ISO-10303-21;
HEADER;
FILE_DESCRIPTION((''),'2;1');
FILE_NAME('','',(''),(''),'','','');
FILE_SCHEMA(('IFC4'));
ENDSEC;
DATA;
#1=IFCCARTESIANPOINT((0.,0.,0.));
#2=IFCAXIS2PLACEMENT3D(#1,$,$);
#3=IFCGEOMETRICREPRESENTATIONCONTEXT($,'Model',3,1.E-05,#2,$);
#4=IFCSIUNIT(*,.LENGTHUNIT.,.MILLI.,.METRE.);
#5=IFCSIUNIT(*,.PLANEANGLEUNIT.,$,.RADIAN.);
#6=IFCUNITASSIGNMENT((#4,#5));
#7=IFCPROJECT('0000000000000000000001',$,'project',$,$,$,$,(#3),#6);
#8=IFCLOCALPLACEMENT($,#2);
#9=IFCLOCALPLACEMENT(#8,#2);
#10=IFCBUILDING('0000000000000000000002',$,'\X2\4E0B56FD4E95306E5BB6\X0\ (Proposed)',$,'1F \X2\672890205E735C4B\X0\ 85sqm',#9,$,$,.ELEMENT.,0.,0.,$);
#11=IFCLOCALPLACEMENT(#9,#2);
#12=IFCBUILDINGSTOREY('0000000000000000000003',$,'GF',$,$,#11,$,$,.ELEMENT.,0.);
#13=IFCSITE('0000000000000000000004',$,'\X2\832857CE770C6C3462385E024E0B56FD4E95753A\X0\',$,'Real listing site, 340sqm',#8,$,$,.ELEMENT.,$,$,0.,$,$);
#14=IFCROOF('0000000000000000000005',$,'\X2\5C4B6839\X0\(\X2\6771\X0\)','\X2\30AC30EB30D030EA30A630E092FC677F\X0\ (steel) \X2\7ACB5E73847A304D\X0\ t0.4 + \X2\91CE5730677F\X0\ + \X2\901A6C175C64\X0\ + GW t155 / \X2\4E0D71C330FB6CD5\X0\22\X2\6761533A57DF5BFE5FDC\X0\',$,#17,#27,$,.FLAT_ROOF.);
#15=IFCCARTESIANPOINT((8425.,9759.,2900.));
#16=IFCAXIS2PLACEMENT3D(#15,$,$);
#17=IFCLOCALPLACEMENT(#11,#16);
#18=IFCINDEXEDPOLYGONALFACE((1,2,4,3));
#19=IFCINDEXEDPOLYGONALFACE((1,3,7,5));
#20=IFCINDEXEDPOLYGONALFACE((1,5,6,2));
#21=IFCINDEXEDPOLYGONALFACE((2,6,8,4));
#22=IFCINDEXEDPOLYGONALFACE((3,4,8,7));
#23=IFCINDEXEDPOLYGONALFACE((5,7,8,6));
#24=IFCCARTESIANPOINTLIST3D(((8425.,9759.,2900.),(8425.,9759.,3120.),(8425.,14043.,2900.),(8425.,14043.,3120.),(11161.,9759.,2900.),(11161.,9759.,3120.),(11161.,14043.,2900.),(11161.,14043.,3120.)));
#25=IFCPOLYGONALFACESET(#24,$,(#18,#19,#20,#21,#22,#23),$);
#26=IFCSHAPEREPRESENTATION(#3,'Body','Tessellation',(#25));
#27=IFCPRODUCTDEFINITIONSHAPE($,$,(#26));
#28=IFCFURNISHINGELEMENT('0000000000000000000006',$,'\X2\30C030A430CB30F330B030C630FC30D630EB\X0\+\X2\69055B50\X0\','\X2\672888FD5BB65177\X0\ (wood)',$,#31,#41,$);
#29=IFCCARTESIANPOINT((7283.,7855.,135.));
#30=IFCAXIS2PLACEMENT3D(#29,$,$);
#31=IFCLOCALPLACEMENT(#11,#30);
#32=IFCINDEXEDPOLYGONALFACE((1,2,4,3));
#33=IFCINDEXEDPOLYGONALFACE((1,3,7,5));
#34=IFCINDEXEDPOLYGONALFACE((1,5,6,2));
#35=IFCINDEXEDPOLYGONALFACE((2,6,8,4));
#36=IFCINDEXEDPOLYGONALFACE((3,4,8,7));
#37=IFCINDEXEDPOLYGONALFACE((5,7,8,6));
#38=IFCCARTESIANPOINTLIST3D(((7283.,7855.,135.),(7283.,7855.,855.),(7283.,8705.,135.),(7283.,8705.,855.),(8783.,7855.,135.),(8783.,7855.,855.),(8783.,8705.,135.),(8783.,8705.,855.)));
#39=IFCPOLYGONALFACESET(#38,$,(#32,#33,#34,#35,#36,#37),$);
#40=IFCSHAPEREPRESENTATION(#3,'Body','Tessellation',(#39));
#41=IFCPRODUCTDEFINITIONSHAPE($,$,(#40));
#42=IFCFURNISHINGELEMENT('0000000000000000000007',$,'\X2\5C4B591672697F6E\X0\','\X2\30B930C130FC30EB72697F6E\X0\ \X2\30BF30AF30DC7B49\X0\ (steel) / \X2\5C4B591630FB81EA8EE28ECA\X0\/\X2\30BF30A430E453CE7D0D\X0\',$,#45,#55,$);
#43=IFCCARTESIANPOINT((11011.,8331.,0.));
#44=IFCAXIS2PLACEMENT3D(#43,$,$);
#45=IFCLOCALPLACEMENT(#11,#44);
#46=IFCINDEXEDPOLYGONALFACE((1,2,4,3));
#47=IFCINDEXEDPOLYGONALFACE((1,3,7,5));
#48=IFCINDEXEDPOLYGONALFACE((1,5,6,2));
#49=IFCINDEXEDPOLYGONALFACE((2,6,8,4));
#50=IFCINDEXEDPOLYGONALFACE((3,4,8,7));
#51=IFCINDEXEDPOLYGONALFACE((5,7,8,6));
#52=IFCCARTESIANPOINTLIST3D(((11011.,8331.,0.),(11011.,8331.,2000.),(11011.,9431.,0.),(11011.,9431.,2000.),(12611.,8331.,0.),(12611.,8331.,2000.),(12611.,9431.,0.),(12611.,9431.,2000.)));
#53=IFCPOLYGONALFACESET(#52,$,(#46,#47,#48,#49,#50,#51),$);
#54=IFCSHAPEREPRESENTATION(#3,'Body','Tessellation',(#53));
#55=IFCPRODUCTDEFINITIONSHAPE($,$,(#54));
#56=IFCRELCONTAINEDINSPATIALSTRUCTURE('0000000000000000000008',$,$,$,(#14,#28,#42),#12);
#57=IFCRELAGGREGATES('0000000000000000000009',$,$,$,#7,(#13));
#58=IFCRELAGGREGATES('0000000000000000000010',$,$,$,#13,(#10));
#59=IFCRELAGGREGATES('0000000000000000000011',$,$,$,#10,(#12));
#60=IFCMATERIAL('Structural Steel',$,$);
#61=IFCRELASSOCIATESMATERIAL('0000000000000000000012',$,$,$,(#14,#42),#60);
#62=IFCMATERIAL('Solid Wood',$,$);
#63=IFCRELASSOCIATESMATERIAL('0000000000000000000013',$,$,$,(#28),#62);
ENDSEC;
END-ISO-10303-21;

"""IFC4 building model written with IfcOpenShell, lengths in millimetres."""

from ifc_helpers import new_model, si_unit, frame, frame_2d, origin, place, context, project, spatial, rectangle, extrude, material, element, save


model = new_model("IFC4")

# Units and contexts
model_context = context("Model", 3, precision=1e-05, world=origin())
ifc_project = project(units=[si_unit("LENGTHUNIT", "METRE", prefix="MILLI"), si_unit("PLANEANGLEUNIT", "RADIAN")], contexts=[model_context])

# Site, building, storey
site_placement = place(None, origin())
site = spatial("IfcSite", under=ifc_project, at=site_placement, Name="茨城県水戸市下国井町", ObjectType="Real listing site, 340sqm", CompositionType="ELEMENT", RefElevation=0.0)
building_placement = place(site_placement, origin())
building = spatial("IfcBuilding", under=site, at=building_placement, Name="下国井の家 (Proposed)", ObjectType="1F 木造平屋 85sqm", CompositionType="ELEMENT", ElevationOfRefHeight=0.0, ElevationOfTerrain=0.0)
storey_placement = place(building_placement, origin())
storey = spatial("IfcBuildingStorey", under=building, at=storey_placement, Name="GF", CompositionType="ELEMENT", Elevation=0.0)

# Shared definitions
ifc_material_1 = material(Name="Solid Wood")

# Roof
ifc_material_2 = material(Name="Structural Steel")
roof_1_placement = place(storey_placement, frame((8425.0, 9759.0, 2900.0)))
element("IfcRoof", 1, at=roof_1_placement, inside=storey, material=ifc_material_2, Name="屋根(東)", Description="ガルバリウム鋼板 (steel) 立平葺き t0.4 + 野地板 + 通気層 + GW t155 / 不燃・法22条区域対応", PredefinedType="FLAT_ROOF", context=model_context, shape_type="SweptSolid", body=[
    extrude(rectangle(XDim=2736.0, YDim=4284.0, at=frame_2d((1368.0, 2142.0))), frame((8425.0, 9759.0, 2900.0)), (0.0, 0.0, 1.0), 220.0),
])

# Furnishing elements
furnishing_1_placement = place(storey_placement, frame((7283.0, 7855.0, 135.0)))
element("IfcFurnishingElement", 2, at=furnishing_1_placement, inside=storey, material=ifc_material_1, Name="ダイニングテーブル+椅子", Description="木製家具 (wood)", context=model_context, shape_type="SweptSolid", body=[
    extrude(rectangle(XDim=1500.0, YDim=850.0, at=frame_2d((750.0, 425.0))), frame((7283.0, 7855.0, 135.0)), (0.0, 0.0, 1.0), 720.0),
])
furnishing_2_placement = place(storey_placement, frame((11011.0, 8331.0, 0.0)))
element("IfcFurnishingElement", 3, at=furnishing_2_placement, inside=storey, material=ifc_material_2, Name="屋外物置", Description="スチール物置 タクボ等 (steel) / 屋外・自転車/タイヤ収納", context=model_context, shape_type="SweptSolid", body=[
    extrude(rectangle(XDim=1600.0, YDim=1100.0, at=frame_2d((800.0, 550.0))), frame((11011.0, 8331.0, 0.0)), (0.0, 0.0, 1.0), 2000.0),
])

save(model, "model.ifc")
